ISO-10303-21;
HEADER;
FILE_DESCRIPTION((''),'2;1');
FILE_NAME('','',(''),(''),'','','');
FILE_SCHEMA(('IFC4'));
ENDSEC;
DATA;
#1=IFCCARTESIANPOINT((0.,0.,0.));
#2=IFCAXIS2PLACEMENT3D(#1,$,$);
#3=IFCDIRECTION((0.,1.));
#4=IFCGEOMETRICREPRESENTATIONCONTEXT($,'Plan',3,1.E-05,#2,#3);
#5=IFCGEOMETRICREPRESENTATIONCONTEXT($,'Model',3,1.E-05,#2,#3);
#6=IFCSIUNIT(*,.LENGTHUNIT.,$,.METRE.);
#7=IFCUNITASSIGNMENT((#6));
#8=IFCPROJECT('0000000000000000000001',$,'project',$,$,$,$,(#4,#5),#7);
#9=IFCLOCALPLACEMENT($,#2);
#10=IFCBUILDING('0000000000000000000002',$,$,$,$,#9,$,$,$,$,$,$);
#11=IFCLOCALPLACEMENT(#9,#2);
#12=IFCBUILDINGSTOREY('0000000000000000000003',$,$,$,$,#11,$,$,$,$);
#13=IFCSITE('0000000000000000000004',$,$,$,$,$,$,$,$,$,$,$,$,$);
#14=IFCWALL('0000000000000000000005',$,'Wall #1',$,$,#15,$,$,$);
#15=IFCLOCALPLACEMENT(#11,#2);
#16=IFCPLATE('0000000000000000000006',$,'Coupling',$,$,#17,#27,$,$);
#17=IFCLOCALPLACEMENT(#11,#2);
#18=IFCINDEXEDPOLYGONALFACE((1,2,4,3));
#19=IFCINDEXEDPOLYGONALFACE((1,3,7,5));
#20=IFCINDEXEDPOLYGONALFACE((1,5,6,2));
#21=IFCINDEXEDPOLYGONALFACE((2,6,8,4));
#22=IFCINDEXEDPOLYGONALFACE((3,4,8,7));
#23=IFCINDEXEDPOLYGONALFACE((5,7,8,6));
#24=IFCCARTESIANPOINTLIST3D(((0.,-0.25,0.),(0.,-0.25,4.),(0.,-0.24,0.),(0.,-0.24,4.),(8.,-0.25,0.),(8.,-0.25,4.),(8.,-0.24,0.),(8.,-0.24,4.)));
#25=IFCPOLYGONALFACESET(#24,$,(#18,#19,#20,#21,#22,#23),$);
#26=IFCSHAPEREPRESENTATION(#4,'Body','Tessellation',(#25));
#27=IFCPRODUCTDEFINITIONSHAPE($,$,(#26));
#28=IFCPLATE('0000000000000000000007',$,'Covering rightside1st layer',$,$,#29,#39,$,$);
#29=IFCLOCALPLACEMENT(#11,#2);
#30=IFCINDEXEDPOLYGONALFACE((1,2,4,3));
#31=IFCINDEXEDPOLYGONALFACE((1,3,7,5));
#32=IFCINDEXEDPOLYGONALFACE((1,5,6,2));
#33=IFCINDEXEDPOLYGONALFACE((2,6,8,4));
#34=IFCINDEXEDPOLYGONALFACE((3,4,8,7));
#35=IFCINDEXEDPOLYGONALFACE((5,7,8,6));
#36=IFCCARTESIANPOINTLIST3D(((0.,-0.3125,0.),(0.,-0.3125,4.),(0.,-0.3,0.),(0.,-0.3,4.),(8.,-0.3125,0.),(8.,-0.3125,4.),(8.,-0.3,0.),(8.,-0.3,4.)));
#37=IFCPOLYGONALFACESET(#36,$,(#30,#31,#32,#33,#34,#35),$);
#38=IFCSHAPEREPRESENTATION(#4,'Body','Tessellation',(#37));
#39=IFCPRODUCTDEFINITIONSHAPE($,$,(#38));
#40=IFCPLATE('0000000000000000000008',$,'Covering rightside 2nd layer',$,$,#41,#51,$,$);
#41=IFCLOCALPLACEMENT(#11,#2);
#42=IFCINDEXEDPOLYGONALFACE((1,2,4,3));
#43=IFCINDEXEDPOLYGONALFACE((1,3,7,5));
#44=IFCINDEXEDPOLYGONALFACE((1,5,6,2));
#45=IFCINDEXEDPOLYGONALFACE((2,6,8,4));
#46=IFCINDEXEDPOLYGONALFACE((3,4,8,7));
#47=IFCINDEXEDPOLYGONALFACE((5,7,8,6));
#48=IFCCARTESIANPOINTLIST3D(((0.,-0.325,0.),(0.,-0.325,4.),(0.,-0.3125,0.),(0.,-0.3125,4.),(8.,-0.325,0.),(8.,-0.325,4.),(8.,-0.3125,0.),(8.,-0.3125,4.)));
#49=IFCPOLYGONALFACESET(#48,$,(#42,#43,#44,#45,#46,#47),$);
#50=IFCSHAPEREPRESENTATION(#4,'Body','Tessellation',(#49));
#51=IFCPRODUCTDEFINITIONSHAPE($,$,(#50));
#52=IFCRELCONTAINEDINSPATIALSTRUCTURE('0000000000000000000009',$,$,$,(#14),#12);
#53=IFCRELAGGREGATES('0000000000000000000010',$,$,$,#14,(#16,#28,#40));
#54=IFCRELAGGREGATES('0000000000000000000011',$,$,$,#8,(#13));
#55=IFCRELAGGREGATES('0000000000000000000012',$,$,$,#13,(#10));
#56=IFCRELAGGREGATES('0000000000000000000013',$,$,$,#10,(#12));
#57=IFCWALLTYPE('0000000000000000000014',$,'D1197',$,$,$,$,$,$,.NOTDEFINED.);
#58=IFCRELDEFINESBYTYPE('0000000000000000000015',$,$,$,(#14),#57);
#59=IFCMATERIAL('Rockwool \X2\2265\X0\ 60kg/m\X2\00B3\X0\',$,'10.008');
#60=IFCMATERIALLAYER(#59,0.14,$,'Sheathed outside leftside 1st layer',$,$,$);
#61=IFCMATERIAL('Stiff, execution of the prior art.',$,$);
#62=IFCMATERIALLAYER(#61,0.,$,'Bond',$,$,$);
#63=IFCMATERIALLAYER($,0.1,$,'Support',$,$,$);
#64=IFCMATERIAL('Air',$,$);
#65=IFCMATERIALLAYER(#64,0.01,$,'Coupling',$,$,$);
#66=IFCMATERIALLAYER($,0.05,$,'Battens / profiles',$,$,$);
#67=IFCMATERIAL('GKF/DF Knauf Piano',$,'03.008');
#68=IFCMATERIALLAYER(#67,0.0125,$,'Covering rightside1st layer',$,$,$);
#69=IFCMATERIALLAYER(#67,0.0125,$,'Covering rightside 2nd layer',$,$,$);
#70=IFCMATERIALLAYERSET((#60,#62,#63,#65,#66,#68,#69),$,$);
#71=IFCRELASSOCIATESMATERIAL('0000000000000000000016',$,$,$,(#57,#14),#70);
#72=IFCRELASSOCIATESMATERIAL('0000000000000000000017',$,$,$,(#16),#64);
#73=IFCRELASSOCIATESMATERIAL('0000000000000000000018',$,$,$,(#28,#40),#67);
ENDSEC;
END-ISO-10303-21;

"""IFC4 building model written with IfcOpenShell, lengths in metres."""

from ifc_helpers import new_model, si_unit, direction, frame, frame_2d, origin, place, context, project, spatial, rectangle, extrude, material, layer, layer_set, type_object, element, aggregate, save


model = new_model("IFC4")

# Units and contexts
plan_context = context("Plan", 3, precision=1e-05, world=origin(), true_north=direction((0.0, 1.0)))
model_context = context("Model", 3, precision=1e-05, world=origin(), true_north=direction((0.0, 1.0)))
ifc_project = project(units=[si_unit("LENGTHUNIT", "METRE")], contexts=[plan_context, model_context])

# Site, building, storey
site = spatial("IfcSite", under=ifc_project)
building_placement = place(None, origin())
building = spatial("IfcBuilding", under=site, at=building_placement)
storey_placement = place(building_placement, origin())
storey = spatial("IfcBuildingStorey", under=building, at=storey_placement)

# Wall, plates
ifc_material_1 = material(Name="Rockwool ≥ 60kg/m³", Category="10.008")
ifc_layer_1 = layer(ifc_material_1, 0.14, Name="Sheathed outside leftside 1st layer")
ifc_material_2 = material(Name="Stiff, execution of the prior art.")
ifc_layer_2 = layer(ifc_material_2, 0.0, Name="Bond")
ifc_layer_3 = layer(None, 0.1, Name="Support")
ifc_material_3 = material(Name="Air")
ifc_layer_4 = layer(ifc_material_3, 0.01, Name="Coupling")
ifc_layer_5 = layer(None, 0.05, Name="Battens / profiles")
ifc_material_4 = material(Name="GKF/DF Knauf Piano", Category="03.008")
ifc_layer_6 = layer(ifc_material_4, 0.0125, Name="Covering rightside1st layer")
ifc_layer_7 = layer(ifc_material_4, 0.0125, Name="Covering rightside 2nd layer")
ifc_layer_set = layer_set([ifc_layer_1, ifc_layer_2, ifc_layer_3, ifc_layer_4, ifc_layer_5, ifc_layer_6, ifc_layer_7])
wall_type = type_object("IfcWallType", Name="D1197", PredefinedType="NOTDEFINED", material=ifc_layer_set)
wall_placement = place(None, frame((0.0, 0.0, 0.0), z_axis=(0.0, -1.0, 0.0), x_axis=(1.0, 0.0, 0.0)))
wall = element("IfcWall", 1, at=wall_placement, inside=storey, type_object=wall_type, material=ifc_layer_set, Name="Wall #1")
plate_1_placement = place(wall_placement, origin())
plate_1 = element("IfcPlate", 2, at=plate_1_placement, material=ifc_material_3, Name="Coupling", context=plan_context, shape_type="SweptSolid", body=[
    extrude(rectangle(XDim=8.0, YDim=4.0, at=frame_2d((4.0, 2.0), x_axis=(1.0, 0.0))), frame((0.0, 0.0, 0.24), z_axis=(0.0, 0.0, 1.0), x_axis=(1.0, 0.0, 0.0)), (0.0, 0.0, 1.0), 0.01),
])
plate_2_placement = place(wall_placement, origin())
plate_2 = element("IfcPlate", 3, at=plate_2_placement, material=ifc_material_4, Name="Covering rightside1st layer", context=plan_context, shape_type="SweptSolid", body=[
    extrude(rectangle(XDim=8.0, YDim=4.0, at=frame_2d((4.0, 2.0), x_axis=(1.0, 0.0))), frame((0.0, 0.0, 0.3), z_axis=(0.0, 0.0, 1.0), x_axis=(1.0, 0.0, 0.0)), (0.0, 0.0, 1.0), 0.0125),
])
plate_3_placement = place(wall_placement, origin())
plate_3 = element("IfcPlate", 4, at=plate_3_placement, material=ifc_material_4, Name="Covering rightside 2nd layer", context=plan_context, shape_type="SweptSolid", body=[
    extrude(rectangle(XDim=8.0, YDim=4.0, at=frame_2d((4.0, 2.0), x_axis=(1.0, 0.0))), frame((0.0, 0.0, 0.3125), z_axis=(0.0, 0.0, 1.0), x_axis=(1.0, 0.0, 0.0)), (0.0, 0.0, 1.0), 0.0125),
])
aggregate(wall, [plate_1, plate_2, plate_3])

save(model, "model.ifc")
